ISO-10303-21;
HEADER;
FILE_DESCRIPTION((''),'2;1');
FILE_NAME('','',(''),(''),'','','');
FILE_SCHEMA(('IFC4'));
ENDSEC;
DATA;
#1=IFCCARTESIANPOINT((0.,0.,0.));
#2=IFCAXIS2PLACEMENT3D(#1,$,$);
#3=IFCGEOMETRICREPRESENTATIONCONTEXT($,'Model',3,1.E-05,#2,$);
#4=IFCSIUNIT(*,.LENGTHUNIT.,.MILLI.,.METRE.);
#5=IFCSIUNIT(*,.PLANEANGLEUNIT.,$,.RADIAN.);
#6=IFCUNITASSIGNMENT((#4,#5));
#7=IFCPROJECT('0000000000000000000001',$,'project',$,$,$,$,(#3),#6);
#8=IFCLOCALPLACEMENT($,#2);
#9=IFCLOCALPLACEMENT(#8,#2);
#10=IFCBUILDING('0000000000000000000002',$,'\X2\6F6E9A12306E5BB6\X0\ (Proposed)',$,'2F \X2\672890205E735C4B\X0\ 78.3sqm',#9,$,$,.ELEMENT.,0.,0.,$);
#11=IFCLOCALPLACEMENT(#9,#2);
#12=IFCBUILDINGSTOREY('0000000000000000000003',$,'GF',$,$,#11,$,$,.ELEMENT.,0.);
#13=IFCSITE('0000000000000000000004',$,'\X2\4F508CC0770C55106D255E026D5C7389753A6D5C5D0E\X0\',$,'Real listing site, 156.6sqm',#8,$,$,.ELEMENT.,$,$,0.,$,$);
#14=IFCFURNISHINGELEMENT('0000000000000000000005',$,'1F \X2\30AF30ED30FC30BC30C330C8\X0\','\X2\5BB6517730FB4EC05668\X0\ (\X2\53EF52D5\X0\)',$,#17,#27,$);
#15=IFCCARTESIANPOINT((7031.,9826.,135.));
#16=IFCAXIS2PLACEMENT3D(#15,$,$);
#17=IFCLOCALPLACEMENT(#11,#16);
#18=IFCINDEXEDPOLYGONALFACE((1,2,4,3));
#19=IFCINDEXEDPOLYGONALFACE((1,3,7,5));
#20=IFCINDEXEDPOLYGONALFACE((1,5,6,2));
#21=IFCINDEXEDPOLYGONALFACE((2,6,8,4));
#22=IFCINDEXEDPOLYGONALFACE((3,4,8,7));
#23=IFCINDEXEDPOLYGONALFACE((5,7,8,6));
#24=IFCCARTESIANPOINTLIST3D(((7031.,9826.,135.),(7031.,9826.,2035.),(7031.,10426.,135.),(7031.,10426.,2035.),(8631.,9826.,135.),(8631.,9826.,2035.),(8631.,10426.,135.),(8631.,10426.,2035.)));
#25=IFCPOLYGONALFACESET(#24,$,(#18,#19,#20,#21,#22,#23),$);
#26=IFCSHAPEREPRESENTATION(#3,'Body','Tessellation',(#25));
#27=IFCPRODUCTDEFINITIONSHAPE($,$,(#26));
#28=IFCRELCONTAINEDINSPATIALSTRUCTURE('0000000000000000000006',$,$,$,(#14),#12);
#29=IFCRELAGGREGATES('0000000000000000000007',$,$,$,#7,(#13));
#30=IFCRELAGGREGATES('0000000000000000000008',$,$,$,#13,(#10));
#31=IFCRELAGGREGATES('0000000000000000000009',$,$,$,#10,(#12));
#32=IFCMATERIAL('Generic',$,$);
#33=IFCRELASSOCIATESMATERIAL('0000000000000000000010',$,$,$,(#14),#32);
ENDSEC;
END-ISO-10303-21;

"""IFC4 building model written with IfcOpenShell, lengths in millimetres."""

from ifc_helpers import new_model, si_unit, frame, frame_2d, origin, place, context, project, spatial, rectangle, extrude, material, element, save


model = new_model("IFC4")

# Units and contexts
model_context = context("Model", 3, precision=1e-05, world=origin())
ifc_project = project(units=[si_unit("LENGTHUNIT", "METRE", prefix="MILLI"), si_unit("PLANEANGLEUNIT", "RADIAN")], contexts=[model_context])

# Site, building, storey
site_placement = place(None, origin())
site = spatial("IfcSite", under=ifc_project, at=site_placement, Name="佐賀県唐津市浜玉町浜崎", ObjectType="Real listing site, 156.6sqm", CompositionType="ELEMENT", RefElevation=0.0)
building_placement = place(site_placement, origin())
building = spatial("IfcBuilding", under=site, at=building_placement, Name="潮騒の家 (Proposed)", ObjectType="2F 木造平屋 78.3sqm", CompositionType="ELEMENT", ElevationOfRefHeight=0.0, ElevationOfTerrain=0.0)
storey_placement = place(building_placement, origin())
storey = spatial("IfcBuildingStorey", under=building, at=storey_placement, Name="GF", CompositionType="ELEMENT", Elevation=0.0)

# Shared definitions
ifc_material_1 = material(Name="Generic")

# Furnishing element
furnishing_placement = place(storey_placement, frame((7031.0, 9826.0, 135.0)))
element("IfcFurnishingElement", 1, at=furnishing_placement, inside=storey, material=ifc_material_1, Name="1F クローゼット", Description="家具・什器 (可動)", context=model_context, shape_type="SweptSolid", body=[
    extrude(rectangle(XDim=1600.0, YDim=600.0, at=frame_2d((800.0, 300.0))), frame((7031.0, 9826.0, 135.0)), (0.0, 0.0, 1.0), 1900.0),
])

save(model, "model.ifc")
